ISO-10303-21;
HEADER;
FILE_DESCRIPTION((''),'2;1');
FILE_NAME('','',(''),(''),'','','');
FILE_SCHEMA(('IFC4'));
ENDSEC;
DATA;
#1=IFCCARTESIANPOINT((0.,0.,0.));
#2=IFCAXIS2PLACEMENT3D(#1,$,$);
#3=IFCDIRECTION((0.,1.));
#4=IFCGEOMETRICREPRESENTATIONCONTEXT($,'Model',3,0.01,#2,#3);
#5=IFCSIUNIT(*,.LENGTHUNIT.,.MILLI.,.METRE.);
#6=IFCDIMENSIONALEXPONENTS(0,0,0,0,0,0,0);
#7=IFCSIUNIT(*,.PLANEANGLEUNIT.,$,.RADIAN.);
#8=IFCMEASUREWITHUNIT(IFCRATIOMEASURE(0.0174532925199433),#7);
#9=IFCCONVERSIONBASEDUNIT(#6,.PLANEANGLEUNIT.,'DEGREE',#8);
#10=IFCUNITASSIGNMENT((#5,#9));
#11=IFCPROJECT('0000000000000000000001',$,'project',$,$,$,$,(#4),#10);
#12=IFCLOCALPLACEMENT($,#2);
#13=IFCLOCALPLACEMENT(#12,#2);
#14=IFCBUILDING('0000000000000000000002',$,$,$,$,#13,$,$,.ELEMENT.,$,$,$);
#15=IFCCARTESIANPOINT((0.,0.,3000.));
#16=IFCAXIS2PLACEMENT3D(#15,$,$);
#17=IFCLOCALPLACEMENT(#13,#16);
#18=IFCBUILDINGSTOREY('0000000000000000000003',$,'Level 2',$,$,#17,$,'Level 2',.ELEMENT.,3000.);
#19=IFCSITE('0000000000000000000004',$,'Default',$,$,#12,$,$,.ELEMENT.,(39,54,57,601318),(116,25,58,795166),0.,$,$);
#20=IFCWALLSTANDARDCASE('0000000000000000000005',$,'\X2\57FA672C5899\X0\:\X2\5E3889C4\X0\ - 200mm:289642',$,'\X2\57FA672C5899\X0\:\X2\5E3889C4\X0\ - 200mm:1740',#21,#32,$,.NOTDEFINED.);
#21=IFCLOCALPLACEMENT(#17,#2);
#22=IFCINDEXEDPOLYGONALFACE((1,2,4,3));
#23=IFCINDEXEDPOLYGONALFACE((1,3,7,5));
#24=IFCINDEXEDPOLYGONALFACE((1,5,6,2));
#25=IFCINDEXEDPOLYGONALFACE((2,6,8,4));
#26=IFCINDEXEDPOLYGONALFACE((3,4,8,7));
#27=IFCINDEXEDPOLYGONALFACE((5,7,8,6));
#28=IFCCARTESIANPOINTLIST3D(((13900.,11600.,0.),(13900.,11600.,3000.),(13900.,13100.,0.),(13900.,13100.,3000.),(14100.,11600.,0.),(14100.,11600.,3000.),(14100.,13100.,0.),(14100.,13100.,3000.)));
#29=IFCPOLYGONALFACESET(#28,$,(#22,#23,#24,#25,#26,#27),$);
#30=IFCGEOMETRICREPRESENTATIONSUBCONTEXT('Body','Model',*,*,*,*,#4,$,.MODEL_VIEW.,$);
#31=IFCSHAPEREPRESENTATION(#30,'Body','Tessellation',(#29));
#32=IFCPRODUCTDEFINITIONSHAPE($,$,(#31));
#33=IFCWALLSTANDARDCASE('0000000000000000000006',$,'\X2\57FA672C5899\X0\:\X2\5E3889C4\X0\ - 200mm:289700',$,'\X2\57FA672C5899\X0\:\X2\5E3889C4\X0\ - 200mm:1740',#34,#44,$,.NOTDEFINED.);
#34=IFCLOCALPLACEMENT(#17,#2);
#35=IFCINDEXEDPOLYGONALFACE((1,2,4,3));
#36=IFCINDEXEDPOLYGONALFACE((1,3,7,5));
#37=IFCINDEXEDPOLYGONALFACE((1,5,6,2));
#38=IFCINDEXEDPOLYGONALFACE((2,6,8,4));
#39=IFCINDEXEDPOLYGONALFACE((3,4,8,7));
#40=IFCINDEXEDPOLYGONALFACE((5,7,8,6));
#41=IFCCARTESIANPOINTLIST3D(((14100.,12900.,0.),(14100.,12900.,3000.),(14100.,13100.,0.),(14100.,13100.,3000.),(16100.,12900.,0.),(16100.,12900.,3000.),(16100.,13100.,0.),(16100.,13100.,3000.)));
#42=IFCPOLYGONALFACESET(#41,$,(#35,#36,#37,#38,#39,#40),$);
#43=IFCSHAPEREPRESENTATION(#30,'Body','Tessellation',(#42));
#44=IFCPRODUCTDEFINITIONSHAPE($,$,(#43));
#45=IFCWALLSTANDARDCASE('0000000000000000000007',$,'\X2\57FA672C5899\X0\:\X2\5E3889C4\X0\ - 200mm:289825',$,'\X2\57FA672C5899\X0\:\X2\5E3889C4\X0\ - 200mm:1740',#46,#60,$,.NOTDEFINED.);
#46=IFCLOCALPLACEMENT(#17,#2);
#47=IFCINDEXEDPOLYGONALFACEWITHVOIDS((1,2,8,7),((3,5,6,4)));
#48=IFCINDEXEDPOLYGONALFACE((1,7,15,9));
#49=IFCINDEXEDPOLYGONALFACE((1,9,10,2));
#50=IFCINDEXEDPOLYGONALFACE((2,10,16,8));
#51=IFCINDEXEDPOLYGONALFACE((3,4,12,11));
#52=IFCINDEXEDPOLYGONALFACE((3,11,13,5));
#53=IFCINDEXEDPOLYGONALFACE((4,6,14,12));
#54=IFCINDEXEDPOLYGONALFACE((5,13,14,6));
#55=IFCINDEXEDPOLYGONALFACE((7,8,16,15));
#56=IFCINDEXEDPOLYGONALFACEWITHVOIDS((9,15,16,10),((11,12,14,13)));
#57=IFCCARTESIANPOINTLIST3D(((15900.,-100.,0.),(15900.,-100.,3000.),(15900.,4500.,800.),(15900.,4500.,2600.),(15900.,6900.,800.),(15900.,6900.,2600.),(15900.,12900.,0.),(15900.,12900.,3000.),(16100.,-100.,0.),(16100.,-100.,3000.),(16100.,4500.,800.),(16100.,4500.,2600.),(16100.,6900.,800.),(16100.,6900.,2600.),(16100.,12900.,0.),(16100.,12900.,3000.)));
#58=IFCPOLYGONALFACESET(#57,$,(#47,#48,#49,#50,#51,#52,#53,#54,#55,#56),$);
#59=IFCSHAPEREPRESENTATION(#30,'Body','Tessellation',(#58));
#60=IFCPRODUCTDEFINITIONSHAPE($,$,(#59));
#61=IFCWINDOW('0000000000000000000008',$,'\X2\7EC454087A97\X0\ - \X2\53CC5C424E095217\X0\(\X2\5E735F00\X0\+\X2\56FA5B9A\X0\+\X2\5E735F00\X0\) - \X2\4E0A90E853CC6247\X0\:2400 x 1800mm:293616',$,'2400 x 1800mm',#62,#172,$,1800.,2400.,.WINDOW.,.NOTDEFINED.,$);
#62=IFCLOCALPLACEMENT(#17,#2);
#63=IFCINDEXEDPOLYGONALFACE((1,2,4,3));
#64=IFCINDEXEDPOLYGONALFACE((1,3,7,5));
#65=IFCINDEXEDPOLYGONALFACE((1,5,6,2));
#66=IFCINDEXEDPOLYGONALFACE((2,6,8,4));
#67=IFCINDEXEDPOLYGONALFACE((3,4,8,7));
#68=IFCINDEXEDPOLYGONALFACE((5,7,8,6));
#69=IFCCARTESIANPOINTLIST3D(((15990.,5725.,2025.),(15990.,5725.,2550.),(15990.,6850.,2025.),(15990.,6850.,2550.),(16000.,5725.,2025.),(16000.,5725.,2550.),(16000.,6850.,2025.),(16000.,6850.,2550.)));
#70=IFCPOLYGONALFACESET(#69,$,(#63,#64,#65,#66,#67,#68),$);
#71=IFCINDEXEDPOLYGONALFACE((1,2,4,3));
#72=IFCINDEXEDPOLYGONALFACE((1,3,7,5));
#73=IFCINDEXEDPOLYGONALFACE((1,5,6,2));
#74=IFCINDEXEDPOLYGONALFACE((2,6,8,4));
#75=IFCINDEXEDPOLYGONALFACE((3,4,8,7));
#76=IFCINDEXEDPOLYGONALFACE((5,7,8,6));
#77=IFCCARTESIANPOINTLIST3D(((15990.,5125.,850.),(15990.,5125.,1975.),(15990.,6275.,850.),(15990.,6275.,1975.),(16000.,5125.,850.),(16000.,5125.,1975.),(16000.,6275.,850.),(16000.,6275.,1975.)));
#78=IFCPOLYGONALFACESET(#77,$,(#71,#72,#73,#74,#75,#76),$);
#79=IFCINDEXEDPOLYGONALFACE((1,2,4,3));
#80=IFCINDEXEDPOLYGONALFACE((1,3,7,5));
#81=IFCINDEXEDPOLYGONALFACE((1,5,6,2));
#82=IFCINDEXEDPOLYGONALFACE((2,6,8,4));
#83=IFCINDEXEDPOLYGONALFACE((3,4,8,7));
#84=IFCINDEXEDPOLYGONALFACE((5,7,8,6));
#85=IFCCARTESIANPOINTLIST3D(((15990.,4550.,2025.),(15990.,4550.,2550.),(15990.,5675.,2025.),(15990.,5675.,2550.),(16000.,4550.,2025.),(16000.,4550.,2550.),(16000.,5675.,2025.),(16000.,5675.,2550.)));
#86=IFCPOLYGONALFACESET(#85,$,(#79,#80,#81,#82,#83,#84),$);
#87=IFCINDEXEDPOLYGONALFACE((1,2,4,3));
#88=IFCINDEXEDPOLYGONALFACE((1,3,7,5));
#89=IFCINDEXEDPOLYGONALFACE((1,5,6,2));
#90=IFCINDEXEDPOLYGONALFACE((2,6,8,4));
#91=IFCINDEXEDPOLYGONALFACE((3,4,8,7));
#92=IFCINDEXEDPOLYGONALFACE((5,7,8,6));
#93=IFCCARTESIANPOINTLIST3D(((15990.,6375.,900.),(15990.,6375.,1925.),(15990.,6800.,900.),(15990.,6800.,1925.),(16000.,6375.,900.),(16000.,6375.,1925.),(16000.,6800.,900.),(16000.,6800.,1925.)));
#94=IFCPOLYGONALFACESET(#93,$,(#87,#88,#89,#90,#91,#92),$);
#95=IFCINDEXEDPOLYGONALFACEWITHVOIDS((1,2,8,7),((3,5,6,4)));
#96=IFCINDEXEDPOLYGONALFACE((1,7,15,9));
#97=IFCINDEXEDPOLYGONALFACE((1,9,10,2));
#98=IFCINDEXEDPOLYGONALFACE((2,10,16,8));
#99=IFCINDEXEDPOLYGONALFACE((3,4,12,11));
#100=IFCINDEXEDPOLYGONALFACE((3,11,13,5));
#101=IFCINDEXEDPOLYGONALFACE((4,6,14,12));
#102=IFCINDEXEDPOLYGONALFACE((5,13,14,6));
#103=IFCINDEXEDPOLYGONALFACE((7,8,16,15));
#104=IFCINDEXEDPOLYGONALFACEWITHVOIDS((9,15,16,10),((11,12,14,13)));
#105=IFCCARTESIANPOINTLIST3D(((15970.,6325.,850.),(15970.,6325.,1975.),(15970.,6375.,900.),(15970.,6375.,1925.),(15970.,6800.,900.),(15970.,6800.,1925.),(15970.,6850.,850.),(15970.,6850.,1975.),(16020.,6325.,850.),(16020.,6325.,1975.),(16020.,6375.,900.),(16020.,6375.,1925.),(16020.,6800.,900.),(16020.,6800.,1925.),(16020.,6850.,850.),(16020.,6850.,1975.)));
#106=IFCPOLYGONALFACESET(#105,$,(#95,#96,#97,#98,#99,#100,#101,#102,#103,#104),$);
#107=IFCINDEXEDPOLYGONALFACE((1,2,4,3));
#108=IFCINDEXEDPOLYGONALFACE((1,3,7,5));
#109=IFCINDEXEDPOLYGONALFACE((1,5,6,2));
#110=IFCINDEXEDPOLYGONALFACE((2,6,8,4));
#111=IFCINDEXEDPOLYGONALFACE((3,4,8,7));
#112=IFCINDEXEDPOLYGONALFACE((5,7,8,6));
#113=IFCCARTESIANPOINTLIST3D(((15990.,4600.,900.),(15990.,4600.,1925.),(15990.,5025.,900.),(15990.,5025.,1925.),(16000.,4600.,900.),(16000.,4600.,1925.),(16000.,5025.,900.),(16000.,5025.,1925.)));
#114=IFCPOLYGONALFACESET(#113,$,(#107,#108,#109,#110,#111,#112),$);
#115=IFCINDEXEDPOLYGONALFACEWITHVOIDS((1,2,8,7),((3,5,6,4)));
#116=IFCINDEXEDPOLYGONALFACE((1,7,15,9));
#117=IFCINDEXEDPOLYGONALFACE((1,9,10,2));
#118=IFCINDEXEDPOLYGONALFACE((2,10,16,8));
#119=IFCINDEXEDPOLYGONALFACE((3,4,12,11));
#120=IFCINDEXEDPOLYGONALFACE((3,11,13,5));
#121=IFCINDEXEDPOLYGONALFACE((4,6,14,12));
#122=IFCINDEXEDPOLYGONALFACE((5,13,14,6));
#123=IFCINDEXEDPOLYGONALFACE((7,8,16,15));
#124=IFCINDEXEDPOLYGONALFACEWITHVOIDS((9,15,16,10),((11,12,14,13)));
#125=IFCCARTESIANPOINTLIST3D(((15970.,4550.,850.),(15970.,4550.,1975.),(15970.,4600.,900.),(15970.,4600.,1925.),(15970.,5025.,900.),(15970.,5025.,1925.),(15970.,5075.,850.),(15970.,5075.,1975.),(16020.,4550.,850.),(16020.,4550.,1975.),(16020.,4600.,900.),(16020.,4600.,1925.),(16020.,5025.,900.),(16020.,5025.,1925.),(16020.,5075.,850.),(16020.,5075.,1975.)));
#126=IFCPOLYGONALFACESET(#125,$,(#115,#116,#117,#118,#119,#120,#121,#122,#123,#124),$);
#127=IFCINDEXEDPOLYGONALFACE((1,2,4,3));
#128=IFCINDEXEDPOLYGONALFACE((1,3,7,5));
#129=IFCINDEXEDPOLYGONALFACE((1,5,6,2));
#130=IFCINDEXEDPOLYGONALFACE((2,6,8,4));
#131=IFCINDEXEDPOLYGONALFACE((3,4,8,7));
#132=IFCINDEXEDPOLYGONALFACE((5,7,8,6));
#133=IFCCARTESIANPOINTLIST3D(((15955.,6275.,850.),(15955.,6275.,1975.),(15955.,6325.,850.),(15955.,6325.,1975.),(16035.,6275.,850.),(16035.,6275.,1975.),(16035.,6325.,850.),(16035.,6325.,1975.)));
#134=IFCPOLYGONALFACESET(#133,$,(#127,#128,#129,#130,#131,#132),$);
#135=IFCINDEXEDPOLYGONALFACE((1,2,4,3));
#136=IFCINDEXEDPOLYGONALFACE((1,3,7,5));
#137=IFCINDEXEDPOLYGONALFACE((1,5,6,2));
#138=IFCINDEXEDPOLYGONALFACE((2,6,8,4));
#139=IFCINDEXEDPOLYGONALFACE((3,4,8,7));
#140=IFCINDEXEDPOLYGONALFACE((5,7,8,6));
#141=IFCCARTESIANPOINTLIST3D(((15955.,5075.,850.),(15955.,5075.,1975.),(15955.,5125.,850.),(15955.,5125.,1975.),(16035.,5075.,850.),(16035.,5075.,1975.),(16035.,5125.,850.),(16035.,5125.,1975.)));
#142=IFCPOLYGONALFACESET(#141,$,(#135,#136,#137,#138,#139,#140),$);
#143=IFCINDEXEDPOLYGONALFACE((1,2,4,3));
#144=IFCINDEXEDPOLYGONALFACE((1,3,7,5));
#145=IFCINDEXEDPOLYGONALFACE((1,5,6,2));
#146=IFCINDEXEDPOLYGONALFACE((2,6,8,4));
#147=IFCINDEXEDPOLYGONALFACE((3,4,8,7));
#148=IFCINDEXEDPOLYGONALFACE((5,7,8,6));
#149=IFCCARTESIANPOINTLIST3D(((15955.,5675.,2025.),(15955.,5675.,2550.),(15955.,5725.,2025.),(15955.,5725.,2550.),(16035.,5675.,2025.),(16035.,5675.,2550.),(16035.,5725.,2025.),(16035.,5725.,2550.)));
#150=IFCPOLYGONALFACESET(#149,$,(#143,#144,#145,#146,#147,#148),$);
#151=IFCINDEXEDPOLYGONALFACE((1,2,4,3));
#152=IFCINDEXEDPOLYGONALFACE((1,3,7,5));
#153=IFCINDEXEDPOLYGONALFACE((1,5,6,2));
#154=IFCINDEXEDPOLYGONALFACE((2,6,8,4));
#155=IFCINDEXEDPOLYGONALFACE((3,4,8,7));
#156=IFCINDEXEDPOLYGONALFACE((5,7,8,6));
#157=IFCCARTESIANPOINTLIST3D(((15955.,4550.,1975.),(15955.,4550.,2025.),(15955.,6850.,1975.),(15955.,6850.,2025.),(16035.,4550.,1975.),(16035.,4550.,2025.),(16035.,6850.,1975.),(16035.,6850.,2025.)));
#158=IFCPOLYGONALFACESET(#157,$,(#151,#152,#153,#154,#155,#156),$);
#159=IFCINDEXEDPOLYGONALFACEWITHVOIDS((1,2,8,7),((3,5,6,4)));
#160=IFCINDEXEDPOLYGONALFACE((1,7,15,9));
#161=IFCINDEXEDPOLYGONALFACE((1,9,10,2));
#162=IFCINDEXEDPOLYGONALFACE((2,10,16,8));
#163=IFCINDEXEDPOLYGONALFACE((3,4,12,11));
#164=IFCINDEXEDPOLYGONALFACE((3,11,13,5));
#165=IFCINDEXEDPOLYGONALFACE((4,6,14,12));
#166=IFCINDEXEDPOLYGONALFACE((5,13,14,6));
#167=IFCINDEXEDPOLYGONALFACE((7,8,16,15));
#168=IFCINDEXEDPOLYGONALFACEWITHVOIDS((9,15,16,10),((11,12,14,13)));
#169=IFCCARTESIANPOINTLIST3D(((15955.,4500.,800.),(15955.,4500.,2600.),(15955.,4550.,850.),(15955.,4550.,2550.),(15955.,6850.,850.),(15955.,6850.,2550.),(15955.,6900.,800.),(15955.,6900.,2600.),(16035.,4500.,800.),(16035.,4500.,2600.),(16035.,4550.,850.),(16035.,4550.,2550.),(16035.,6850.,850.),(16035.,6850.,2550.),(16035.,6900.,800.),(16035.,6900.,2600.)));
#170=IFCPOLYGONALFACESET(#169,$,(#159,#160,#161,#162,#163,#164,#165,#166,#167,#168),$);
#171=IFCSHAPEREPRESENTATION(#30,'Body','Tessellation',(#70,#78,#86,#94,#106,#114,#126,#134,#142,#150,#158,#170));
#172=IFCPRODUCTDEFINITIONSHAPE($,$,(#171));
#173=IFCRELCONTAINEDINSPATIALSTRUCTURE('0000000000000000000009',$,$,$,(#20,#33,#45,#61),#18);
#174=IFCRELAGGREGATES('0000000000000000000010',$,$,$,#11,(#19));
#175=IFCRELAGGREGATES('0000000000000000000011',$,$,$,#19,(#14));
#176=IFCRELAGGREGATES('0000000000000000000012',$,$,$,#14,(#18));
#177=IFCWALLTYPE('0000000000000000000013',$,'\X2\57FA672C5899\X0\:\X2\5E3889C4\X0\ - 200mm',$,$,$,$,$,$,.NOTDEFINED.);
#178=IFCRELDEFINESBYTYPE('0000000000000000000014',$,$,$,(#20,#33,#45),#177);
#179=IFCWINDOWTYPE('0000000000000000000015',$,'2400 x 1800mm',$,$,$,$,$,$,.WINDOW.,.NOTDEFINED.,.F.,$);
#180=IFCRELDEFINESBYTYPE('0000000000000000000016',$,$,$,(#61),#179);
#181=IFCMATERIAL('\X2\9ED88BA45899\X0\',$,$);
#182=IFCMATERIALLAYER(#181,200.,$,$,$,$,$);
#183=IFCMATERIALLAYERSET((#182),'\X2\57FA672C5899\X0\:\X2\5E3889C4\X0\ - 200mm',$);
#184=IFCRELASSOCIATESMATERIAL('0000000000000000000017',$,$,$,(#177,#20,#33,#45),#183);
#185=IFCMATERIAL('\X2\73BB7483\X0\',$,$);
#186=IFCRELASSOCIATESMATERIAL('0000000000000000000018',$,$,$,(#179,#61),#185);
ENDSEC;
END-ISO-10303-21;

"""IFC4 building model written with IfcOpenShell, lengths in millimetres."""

from ifc_helpers import new_model, entity, si_unit, converted_unit, direction, frame, frame_2d, origin, origin_2d_with_axis, place, context, subcontext, project, spatial, polyline, rectangle, outline, extrude, source, transform, mapped, material, layer, layer_set, layer_usage, type_object, type_shapes, element, fill, save


model = new_model("IFC4")

# Units and contexts
model_context = context("Model", 3, precision=0.01, world=origin(), true_north=direction((0.0, 1.0)))
body_context = subcontext(model_context, "Body", "Model", "MODEL_VIEW")
ifc_project = project(units=[si_unit("LENGTHUNIT", "METRE", prefix="MILLI"), converted_unit("PLANEANGLEUNIT", "DEGREE", entity("IfcRatioMeasure", 0.0174532925199433), si_unit("PLANEANGLEUNIT", "RADIAN"), dimensions=[0, 0, 0, 0, 0, 0, 0])], contexts=[model_context])

# Site, building, storey
site_placement = place(None, origin())
site = spatial("IfcSite", under=ifc_project, at=site_placement, Name="Default", CompositionType="ELEMENT", RefLatitude=(39, 54, 57, 601318), RefLongitude=(116, 25, 58, 795166), RefElevation=0.0)
building_placement = place(site_placement, origin())
building = spatial("IfcBuilding", under=site, at=building_placement, CompositionType="ELEMENT")
storey_placement = place(building_placement, frame((0.0, 0.0, 3000.0)))
storey = spatial("IfcBuildingStorey", under=building, at=storey_placement, Name="Level 2", LongName="Level 2", CompositionType="ELEMENT", Elevation=3000.0)

# Shared definitions
ifc_material_1 = material(Name="默认墙")
ifc_layer = layer(ifc_material_1, 200.0)
ifc_layer_set = layer_set([ifc_layer], Name="基本墙:常规 - 200mm")
wall_type = type_object("IfcWallType", Name="基本墙:常规 - 200mm", PredefinedType="NOTDEFINED", material=ifc_layer_set)

# Walls
ifc_layer_usage_1 = layer_usage(ifc_layer_set, "AXIS2", "NEGATIVE", 100.0)
wall_1_placement = place(storey_placement, frame((14000.0, 11600.0, 0.0), z_axis=(0.0, 0.0, 1.0), x_axis=(0.0, 1.0, 0.0)))
element("IfcWallStandardCase", 1, at=wall_1_placement, inside=storey, type_object=wall_type, material=ifc_layer_usage_1, Name="基本墙:常规 - 200mm:289642", ObjectType="基本墙:常规 - 200mm:1740", PredefinedType="NOTDEFINED", context=body_context, shape_type="SweptSolid", body=[
    extrude(rectangle(XDim=1500.0, YDim=200.0, at=frame_2d((750.0, 0.0), x_axis=(-1.0, 0.0))), origin(), (0.0, 0.0, 1.0), 3000.0),
])
ifc_layer_usage_2 = layer_usage(ifc_layer_set, "AXIS2", "NEGATIVE", 100.0)
wall_2_placement = place(storey_placement, frame((14100.0, 13000.0, 0.0)))
element("IfcWallStandardCase", 2, at=wall_2_placement, inside=storey, type_object=wall_type, material=ifc_layer_usage_2, Name="基本墙:常规 - 200mm:289700", ObjectType="基本墙:常规 - 200mm:1740", PredefinedType="NOTDEFINED", context=body_context, shape_type="SweptSolid", body=[
    extrude(rectangle(XDim=2000.0, YDim=200.0, at=frame_2d((1000.0, 0.0), x_axis=(-1.0, 0.0))), origin(), (0.0, 0.0, 1.0), 3000.0),
])

# Wall, opening, window
ifc_layer_usage_3 = layer_usage(ifc_layer_set, "AXIS2", "NEGATIVE", 100.0)
wall_3_placement = place(storey_placement, frame((16000.0, 12900.0, 0.0), z_axis=(0.0, 0.0, 1.0), x_axis=(0.0, -1.0, 0.0)))
wall_3 = element("IfcWallStandardCase", 3, at=wall_3_placement, inside=storey, type_object=wall_type, material=ifc_layer_usage_3, Name="基本墙:常规 - 200mm:289825", ObjectType="基本墙:常规 - 200mm:1740", PredefinedType="NOTDEFINED", context=body_context, shape_type="SweptSolid", body=[
    extrude(rectangle(XDim=13000.0, YDim=200.0, at=frame_2d((6500.0, 0.0), x_axis=(-1.0, 0.0))), origin(), (0.0, 0.0, 1.0), 3000.0),
])
opening_1_placement = place(wall_3_placement, frame((6000.0, -100.0, 800.0)))
opening_1 = element("IfcOpeningElement", 4, at=opening_1_placement, cuts=wall_3, ObjectType="Opening", PredefinedType="OPENING", context=body_context, shape_type="SweptSolid", body=[
    extrude(rectangle(XDim=1800.0, YDim=2400.0, at=frame_2d((900.0, 1200.0), x_axis=(1.0, 0.0))), frame((0.0, 0.0, 0.0), z_axis=(0.0, 1.0, 0.0), x_axis=(0.0, 0.0, 1.0)), (0.0, 0.0, 1.0), 200.0),
])
ifc_material_2 = material(Name="玻璃")
window_type_1 = type_object("IfcWindowType", Name="2400 x 1800mm", ParameterTakesPrecedence=False, PartitioningType="NOTDEFINED", PredefinedType="WINDOW", material=ifc_material_2)
shared_shape_1 = source(origin(), body_context, "Body", "SweptSolid", [
    extrude(rectangle(XDim=10.0, YDim=1125.0, at=origin_2d_with_axis()), frame((612.5, 95.0, 1225.0), z_axis=(0.0, 0.0, 1.0), x_axis=(0.0, 1.0, 0.0)), (0.0, 0.0, 1.0), 525.0),
    extrude(rectangle(XDim=10.0, YDim=1150.0, at=origin_2d_with_axis()), frame((1200.0, 95.0, 50.0), z_axis=(0.0, 0.0, 1.0), x_axis=(0.0, 1.0, 0.0)), (0.0, 0.0, 1.0), 1125.0),
    extrude(rectangle(XDim=10.0, YDim=1125.0, at=origin_2d_with_axis()), frame((1787.5, 95.0, 1225.0), z_axis=(0.0, 0.0, 1.0), x_axis=(0.0, 1.0, 0.0)), (0.0, 0.0, 1.0), 525.0),
    extrude(rectangle(XDim=10.0, YDim=425.0, at=origin_2d_with_axis()), frame((312.5, 95.0, 100.0), z_axis=(0.0, 0.0, 1.0), x_axis=(0.0, 1.0, 0.0)), (0.0, 0.0, 1.0), 1025.0),
    extrude(outline(polyline([(-562.5, -262.5), (562.5, -262.5), (562.5, 262.5), (-562.5, 262.5), (-562.5, -262.5)]), holes=[polyline([(512.5, -212.5), (-512.5, -212.5), (-512.5, 212.5), (512.5, 212.5), (512.5, -212.5)])]), frame((312.5, 70.0, 612.5), z_axis=(0.0, 1.0, 0.0), x_axis=(0.0, 0.0, -1.0)), (0.0, 0.0, 1.0), 50.0),
    extrude(rectangle(XDim=10.0, YDim=425.0, at=origin_2d_with_axis()), frame((2087.5, 95.0, 100.0), z_axis=(0.0, 0.0, 1.0), x_axis=(0.0, 1.0, 0.0)), (0.0, 0.0, 1.0), 1025.0),
    extrude(outline(polyline([(-562.5, -262.5), (562.5, -262.5), (562.5, 262.5), (-562.5, 262.5), (-562.5, -262.5)]), holes=[polyline([(512.5, -212.5), (-512.5, -212.5), (-512.5, 212.5), (512.5, 212.5), (512.5, -212.5)])]), frame((2087.5, 70.0, 612.5), z_axis=(0.0, 1.0, 0.0), x_axis=(0.0, 0.0, -1.0)), (0.0, 0.0, 1.0), 50.0),
    extrude(rectangle(XDim=80.0, YDim=50.0, at=origin_2d_with_axis()), frame((600.0, 95.0, 50.0), z_axis=(0.0, 0.0, 1.0), x_axis=(0.0, -1.0, 0.0)), (0.0, 0.0, 1.0), 1125.0),
    extrude(rectangle(XDim=80.0, YDim=50.0, at=origin_2d_with_axis()), frame((1800.0, 95.0, 50.0), z_axis=(0.0, 0.0, 1.0), x_axis=(0.0, -1.0, 0.0)), (0.0, 0.0, 1.0), 1125.0),
    extrude(rectangle(XDim=80.0, YDim=50.0, at=origin_2d_with_axis()), frame((1200.0, 95.0, 1225.0), z_axis=(0.0, 0.0, 1.0), x_axis=(0.0, -1.0, 0.0)), (0.0, 0.0, 1.0), 525.0),
    extrude(rectangle(XDim=80.0, YDim=2300.0, at=origin_2d_with_axis()), frame((1200.0, 95.0, 1175.0), z_axis=(0.0, 0.0, 1.0), x_axis=(0.0, -1.0, 0.0)), (0.0, 0.0, 1.0), 50.0),
    extrude(outline(polyline([(-1200.0, -900.0), (1200.0, -900.0), (1200.0, 900.0), (-1200.0, 900.0), (-1200.0, -900.0)]), holes=[polyline([(1150.0, -850.0), (-1150.0, -850.0), (-1150.0, 850.0), (1150.0, 850.0), (1150.0, -850.0)])]), frame((1200.0, 55.0, 900.0), z_axis=(0.0, 1.0, 0.0), x_axis=(1.0, 0.0, 0.0)), (0.0, 0.0, 1.0), 80.0),
])
type_shapes(window_type_1, [shared_shape_1])
window_1_placement = place(opening_1_placement, origin())
window_1 = element("IfcWindow", 5, at=window_1_placement, inside=storey, type_object=window_type_1, material=ifc_material_2, Name="组合窗 - 双层三列(平开+固定+平开) - 上部双扇:2400 x 1800mm:293616", ObjectType="2400 x 1800mm", OverallHeight=1800.0, OverallWidth=2400.0, PartitioningType="NOTDEFINED", PredefinedType="WINDOW", context=body_context, shape_type="MappedRepresentation", body=[
    mapped(shared_shape_1, transform((0.0, 0.0, 0.0), scale=1.0)),
])
fill(opening_1, window_1)

save(model, "model.ifc")
